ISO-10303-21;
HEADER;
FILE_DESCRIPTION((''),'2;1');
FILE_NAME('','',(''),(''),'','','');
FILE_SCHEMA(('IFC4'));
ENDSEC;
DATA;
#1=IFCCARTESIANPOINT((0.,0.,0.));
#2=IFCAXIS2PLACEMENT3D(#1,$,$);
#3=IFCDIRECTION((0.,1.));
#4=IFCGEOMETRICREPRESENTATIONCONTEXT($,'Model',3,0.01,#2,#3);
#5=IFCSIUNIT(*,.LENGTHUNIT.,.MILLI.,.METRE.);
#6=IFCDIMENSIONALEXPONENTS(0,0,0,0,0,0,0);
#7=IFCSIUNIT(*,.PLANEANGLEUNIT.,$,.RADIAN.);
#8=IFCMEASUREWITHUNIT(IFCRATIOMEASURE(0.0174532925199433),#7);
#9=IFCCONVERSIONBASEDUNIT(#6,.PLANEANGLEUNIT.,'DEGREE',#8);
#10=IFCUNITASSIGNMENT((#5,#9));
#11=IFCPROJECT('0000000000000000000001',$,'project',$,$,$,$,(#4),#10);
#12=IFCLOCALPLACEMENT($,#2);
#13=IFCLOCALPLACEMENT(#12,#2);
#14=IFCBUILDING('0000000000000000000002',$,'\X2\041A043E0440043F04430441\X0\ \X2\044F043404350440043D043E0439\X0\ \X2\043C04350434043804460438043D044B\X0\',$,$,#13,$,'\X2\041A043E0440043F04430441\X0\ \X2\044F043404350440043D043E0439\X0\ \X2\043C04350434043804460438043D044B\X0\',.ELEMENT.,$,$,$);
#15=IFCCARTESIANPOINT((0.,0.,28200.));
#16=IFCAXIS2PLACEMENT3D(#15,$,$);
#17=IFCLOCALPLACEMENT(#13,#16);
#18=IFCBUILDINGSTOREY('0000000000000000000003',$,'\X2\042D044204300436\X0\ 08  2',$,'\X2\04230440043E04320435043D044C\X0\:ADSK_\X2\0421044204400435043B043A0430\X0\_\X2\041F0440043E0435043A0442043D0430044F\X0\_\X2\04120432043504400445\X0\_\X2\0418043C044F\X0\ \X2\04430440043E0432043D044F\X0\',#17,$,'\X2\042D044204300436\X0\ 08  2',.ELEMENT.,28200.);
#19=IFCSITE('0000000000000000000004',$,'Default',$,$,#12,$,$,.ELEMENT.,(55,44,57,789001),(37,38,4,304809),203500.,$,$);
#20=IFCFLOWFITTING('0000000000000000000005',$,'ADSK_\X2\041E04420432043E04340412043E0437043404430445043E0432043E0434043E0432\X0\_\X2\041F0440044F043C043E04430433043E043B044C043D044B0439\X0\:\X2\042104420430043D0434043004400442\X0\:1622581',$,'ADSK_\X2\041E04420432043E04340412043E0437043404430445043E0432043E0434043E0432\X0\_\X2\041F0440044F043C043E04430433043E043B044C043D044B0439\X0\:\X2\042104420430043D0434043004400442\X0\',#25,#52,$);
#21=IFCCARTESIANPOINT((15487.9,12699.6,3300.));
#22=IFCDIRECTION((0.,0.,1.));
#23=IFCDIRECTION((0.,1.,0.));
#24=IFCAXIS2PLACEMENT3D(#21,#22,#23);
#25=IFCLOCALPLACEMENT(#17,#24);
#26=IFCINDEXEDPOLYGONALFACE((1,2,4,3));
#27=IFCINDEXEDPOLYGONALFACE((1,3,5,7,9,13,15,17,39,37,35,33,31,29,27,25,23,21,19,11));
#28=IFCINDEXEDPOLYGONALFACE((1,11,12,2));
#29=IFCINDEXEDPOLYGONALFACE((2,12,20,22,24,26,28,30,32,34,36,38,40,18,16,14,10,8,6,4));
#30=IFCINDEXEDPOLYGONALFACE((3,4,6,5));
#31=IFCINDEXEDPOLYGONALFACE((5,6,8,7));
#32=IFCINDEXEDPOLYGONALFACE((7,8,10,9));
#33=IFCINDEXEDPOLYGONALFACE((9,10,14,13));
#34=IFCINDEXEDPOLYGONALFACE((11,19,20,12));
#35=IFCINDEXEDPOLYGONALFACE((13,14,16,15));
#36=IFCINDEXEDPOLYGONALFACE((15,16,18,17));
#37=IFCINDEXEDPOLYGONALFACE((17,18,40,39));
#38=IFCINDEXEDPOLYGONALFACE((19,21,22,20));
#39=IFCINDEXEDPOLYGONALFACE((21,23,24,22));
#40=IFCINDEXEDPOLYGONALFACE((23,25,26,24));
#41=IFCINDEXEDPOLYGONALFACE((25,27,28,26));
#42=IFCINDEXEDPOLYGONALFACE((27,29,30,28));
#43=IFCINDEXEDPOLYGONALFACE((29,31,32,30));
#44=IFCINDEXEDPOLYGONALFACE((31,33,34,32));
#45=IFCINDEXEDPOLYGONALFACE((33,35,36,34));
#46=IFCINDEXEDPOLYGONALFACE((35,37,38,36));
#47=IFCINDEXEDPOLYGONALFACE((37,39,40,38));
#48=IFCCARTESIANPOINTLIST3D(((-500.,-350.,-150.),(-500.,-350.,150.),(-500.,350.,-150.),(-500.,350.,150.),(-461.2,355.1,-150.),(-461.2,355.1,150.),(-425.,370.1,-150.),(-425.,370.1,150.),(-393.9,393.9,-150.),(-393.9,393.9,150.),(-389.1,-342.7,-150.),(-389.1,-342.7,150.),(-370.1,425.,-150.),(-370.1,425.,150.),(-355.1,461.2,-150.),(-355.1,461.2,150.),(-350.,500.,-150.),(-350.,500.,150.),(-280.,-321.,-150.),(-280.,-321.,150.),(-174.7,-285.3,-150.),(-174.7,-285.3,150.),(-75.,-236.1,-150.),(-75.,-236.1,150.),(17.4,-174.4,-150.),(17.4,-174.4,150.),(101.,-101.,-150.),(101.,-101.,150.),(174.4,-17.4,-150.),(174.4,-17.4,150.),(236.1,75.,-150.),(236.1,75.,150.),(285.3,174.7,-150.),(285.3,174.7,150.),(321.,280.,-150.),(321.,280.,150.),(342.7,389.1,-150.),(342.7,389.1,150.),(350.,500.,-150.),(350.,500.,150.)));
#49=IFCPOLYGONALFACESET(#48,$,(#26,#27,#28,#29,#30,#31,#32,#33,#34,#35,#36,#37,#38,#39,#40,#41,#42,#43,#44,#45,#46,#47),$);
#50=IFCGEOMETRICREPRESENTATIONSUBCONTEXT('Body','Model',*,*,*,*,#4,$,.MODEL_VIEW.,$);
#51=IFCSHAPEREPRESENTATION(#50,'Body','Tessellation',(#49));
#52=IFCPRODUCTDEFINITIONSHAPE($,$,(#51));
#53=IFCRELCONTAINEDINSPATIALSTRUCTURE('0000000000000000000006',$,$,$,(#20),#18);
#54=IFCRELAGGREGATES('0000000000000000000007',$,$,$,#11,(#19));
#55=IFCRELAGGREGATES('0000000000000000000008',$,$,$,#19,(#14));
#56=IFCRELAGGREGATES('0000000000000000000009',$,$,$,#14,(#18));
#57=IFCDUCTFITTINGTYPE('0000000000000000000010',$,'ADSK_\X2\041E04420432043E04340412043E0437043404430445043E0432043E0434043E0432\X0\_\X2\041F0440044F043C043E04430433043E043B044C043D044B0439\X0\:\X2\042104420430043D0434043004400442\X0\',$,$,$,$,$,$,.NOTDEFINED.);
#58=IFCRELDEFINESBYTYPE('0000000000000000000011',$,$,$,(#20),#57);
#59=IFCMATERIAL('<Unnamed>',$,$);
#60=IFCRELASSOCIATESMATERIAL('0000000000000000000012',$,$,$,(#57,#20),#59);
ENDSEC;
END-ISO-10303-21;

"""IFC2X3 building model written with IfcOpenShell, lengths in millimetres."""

from ifc_helpers import new_model, entity, si_unit, converted_unit, direction, frame, frame_2d, origin, place, context, subcontext, project, spatial, polyline, circle_curve, parameter, trimmed, segment, composite_curve, outline, extrude, source, transform, mapped, material, type_object, type_shapes, element, save


model = new_model("IFC2X3")

# Units and contexts
model_context = context("Model", 3, precision=0.01, world=origin(), true_north=direction((0.0, 1.0)))
body_context = subcontext(model_context, "Body", "Model", "MODEL_VIEW")
ifc_project = project(units=[si_unit("LENGTHUNIT", "METRE", prefix="MILLI"), converted_unit("PLANEANGLEUNIT", "DEGREE", entity("IfcRatioMeasure", 0.0174532925199433), si_unit("PLANEANGLEUNIT", "RADIAN"), dimensions=[0, 0, 0, 0, 0, 0, 0])], contexts=[model_context])

# Site, building, storey
site_placement = place(None, origin())
site = spatial("IfcSite", under=ifc_project, at=site_placement, Name="Default", CompositionType="ELEMENT", RefLatitude=(55, 44, 57, 789001), RefLongitude=(37, 38, 4, 304809), RefElevation=203500.0)
building_placement = place(site_placement, origin())
building = spatial("IfcBuilding", under=site, at=building_placement, Name="Корпус ядерной медицины", LongName="Корпус ядерной медицины", CompositionType="ELEMENT")
storey_placement = place(building_placement, frame((0.0, 0.0, 28200.0)))
storey = spatial("IfcBuildingStorey", under=building, at=storey_placement, Name="Этаж 08  2", ObjectType="Уровень:ADSK_Стрелка_Проектная_Вверх_Имя уровня", LongName="Этаж 08  2", CompositionType="ELEMENT", Elevation=28200.0)

# Flow fitting
ifc_material = material(Name="<Unnamed>")
duct_fitting_type_1 = type_object("IfcDuctFittingType", Name="ADSK_ОтводВоздуховодов_Прямоугольный:Стандарт", PredefinedType="NOTDEFINED", material=ifc_material)
shared_shape_1 = source(origin(), body_context, "Body", "SweptSolid", [
    extrude(outline(composite_curve([segment(polyline([(-600.0, -250.0), (100.0, -250.0)]), True, "CONTINUOUS"), segment(trimmed(circle_curve(frame_2d((250.0, -250.0), x_axis=(0.0, 1.0)), 150.0), [parameter(0.0)], [parameter(90.0)], True, "PARAMETER"), False, "CONTINUOUS"), segment(polyline([(250.0, -100.0), (250.0, 600.0)]), True, "CONTINUOUS"), segment(trimmed(circle_curve(frame_2d((250.0, -250.0), x_axis=(0.0, 1.0)), 850.0), [parameter(0.0)], [parameter(90.0)], True, "PARAMETER"), True, "CONTINUOUS")], self_intersect=False)), frame((-250.0, 250.0, -150.0), z_axis=(0.0, 0.0, 1.0), x_axis=(-1.0, 0.0, 0.0)), (0.0, 0.0, 1.0), 300.0),
])
type_shapes(duct_fitting_type_1, [shared_shape_1])
flow_fitting_1_placement = place(storey_placement, frame((15487.9, 12699.6, 3300.0), z_axis=(0.0, 0.0, 1.0), x_axis=(0.0, 1.0, 0.0)))
element("IfcFlowFitting", 1, at=flow_fitting_1_placement, inside=storey, type_object=duct_fitting_type_1, material=ifc_material, Name="ADSK_ОтводВоздуховодов_Прямоугольный:Стандарт:1622581", ObjectType="ADSK_ОтводВоздуховодов_Прямоугольный:Стандарт", context=body_context, shape_type="MappedRepresentation", body=[
    mapped(shared_shape_1, transform((0.0, 0.0, 0.0), scale=1.0)),
])

save(model, "model.ifc")
